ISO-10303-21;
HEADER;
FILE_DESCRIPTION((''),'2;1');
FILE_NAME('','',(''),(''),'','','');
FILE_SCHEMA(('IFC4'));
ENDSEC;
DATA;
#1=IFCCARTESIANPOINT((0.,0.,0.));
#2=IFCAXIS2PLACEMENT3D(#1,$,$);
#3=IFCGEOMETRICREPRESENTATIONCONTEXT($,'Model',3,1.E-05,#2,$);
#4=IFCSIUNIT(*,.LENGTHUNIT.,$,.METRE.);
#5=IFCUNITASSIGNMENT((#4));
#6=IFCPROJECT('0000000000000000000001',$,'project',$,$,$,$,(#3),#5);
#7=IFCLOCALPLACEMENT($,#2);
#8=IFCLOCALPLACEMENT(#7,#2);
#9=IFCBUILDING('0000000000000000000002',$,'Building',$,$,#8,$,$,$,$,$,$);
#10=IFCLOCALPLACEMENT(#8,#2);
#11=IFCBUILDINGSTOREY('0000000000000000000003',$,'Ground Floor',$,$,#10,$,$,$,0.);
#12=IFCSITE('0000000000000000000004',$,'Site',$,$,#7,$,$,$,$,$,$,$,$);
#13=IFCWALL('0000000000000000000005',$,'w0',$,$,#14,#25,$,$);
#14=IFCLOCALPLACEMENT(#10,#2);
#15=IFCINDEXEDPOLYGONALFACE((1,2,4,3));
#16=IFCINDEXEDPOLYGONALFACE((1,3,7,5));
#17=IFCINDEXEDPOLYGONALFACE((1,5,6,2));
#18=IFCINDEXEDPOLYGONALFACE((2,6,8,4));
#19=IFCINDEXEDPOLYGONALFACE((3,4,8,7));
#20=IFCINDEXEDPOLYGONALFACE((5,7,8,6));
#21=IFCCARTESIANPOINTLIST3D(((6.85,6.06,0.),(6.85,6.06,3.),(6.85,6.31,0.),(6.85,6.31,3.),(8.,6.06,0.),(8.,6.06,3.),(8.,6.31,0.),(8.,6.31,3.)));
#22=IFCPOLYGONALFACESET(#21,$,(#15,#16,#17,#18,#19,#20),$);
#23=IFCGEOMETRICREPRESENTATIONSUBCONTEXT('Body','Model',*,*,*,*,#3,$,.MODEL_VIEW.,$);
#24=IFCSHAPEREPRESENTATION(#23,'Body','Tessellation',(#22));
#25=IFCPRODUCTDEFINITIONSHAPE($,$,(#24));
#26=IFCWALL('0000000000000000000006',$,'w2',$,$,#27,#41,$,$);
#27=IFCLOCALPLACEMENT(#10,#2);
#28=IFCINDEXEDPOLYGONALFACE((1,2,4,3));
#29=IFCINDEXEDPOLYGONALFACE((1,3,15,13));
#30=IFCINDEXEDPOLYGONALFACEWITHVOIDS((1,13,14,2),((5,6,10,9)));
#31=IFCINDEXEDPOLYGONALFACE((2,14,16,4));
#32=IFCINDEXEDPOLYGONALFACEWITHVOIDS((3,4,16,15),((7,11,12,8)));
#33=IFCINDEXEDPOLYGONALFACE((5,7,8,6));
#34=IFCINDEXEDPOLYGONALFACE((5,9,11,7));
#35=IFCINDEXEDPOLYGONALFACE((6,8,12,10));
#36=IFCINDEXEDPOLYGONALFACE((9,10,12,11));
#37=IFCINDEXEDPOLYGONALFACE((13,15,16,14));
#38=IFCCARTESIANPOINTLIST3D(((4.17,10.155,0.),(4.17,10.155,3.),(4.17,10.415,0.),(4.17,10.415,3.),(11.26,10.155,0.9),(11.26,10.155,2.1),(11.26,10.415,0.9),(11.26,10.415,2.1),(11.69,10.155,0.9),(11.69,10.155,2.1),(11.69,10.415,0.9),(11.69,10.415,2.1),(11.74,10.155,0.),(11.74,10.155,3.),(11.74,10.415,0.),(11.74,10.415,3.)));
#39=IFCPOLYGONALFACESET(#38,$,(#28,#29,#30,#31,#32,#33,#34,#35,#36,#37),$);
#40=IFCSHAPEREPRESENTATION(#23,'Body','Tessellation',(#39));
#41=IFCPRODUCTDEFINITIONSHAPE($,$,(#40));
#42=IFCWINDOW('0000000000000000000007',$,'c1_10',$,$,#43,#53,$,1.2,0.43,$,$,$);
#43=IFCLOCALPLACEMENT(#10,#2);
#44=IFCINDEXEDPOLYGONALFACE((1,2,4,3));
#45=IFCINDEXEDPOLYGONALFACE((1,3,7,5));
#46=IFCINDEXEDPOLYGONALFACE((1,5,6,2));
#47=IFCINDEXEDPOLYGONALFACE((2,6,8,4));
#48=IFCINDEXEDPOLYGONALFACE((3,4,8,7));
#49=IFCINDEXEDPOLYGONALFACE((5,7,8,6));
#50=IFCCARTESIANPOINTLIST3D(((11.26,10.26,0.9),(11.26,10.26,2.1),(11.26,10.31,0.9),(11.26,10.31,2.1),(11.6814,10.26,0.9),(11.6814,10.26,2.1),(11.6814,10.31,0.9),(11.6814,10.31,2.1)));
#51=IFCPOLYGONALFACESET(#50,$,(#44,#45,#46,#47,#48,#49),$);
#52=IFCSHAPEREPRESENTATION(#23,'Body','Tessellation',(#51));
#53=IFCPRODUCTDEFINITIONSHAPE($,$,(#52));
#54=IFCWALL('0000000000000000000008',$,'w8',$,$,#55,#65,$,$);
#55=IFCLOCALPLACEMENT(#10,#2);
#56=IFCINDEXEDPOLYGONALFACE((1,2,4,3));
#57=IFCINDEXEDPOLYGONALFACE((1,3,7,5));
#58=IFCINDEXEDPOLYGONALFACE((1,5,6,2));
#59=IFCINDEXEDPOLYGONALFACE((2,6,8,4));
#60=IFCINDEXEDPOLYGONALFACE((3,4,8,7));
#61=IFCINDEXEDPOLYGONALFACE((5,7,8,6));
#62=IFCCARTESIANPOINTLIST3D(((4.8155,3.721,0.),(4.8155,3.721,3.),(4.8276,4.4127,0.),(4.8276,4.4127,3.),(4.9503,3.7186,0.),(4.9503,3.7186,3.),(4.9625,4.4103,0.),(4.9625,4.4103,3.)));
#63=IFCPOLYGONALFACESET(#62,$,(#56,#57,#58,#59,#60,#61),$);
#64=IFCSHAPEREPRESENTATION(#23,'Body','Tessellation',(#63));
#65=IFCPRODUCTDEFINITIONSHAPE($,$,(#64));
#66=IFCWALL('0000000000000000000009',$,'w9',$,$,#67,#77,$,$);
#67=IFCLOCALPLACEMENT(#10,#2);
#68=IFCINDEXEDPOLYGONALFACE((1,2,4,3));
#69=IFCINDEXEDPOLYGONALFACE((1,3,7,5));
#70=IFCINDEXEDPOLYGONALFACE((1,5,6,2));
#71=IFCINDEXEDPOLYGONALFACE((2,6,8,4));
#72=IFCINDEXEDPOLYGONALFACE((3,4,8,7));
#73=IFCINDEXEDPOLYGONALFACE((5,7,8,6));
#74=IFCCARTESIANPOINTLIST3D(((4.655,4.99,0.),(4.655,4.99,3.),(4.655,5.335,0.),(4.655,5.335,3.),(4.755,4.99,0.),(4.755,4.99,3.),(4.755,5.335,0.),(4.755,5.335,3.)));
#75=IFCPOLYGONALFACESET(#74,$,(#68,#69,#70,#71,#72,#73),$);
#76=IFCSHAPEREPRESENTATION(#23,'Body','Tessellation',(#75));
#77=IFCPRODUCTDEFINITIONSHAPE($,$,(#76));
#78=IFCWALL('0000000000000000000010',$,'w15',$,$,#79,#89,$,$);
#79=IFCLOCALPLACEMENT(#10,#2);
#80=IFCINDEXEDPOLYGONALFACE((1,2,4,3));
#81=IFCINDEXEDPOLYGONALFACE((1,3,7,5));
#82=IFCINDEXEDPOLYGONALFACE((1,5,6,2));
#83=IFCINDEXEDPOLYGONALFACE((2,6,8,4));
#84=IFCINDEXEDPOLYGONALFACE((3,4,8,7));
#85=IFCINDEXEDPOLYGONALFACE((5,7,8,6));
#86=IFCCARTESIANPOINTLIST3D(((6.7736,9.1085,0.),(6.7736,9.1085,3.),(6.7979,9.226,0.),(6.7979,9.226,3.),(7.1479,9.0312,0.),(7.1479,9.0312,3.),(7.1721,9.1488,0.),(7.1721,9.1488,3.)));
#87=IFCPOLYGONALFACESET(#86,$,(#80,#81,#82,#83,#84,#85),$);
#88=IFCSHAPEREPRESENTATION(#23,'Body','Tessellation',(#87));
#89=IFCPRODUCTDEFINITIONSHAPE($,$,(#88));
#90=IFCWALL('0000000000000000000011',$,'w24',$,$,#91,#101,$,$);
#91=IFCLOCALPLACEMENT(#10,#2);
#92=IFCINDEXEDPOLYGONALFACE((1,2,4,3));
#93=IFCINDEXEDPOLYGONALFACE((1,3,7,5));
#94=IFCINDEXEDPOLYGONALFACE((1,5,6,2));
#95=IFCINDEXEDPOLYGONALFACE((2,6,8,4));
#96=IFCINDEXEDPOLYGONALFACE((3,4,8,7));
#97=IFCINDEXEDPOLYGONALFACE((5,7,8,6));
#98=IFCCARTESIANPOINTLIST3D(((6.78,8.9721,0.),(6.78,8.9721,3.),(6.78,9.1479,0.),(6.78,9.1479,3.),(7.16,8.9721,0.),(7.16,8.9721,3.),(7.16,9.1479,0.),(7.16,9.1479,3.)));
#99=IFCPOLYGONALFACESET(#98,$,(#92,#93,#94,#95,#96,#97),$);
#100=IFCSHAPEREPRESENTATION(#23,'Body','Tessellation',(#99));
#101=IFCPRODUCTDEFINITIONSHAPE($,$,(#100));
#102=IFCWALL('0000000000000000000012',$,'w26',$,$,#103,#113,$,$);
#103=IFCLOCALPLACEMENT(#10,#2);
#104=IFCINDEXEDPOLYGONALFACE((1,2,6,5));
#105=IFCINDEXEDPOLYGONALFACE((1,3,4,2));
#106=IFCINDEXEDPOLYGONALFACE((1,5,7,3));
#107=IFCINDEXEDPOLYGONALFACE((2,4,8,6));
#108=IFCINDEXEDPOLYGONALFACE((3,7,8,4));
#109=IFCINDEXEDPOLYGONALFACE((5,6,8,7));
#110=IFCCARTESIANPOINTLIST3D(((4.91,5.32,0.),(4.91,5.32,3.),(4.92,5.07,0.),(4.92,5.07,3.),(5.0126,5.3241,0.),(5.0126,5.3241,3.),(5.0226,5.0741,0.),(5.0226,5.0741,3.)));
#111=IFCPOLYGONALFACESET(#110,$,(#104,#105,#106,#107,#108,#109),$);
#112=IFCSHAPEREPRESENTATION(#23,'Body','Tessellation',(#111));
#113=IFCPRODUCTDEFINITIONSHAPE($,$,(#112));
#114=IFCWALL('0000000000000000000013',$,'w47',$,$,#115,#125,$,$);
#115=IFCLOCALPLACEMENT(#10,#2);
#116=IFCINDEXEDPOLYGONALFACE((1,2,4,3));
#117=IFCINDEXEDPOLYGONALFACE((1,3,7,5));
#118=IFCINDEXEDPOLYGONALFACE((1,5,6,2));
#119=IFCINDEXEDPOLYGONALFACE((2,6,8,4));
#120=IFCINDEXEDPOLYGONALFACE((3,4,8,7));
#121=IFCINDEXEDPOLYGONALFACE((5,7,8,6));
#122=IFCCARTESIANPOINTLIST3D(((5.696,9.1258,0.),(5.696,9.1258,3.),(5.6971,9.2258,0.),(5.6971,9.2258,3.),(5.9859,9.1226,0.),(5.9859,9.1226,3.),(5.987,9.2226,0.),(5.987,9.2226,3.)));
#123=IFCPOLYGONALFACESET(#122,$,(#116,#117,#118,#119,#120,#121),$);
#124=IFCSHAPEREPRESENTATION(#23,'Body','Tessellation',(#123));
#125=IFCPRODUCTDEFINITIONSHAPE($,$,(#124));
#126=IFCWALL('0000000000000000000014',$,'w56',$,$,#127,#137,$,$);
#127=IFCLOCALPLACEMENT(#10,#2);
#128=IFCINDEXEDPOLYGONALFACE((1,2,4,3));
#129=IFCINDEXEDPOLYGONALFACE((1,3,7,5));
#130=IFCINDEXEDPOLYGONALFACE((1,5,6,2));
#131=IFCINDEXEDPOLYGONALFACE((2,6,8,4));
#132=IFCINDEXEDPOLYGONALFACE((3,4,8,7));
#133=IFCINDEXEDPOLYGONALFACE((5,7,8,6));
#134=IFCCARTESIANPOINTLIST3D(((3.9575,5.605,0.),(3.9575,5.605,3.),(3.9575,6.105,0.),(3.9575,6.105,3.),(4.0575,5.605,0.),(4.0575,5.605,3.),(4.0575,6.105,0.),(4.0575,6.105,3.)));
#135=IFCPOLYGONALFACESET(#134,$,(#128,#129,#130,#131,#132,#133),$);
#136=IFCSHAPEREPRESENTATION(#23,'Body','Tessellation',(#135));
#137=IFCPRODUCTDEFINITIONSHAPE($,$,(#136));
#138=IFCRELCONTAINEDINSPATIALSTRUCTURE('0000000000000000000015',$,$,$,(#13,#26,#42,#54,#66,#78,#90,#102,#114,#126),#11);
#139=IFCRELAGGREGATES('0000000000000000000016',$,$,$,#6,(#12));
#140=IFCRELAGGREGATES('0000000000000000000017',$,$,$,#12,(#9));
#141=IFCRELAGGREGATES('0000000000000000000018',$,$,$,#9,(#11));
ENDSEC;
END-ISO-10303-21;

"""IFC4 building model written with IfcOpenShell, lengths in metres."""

from ifc_helpers import new_model, si_unit, frame, origin, place, context, subcontext, project, spatial, polyline, outline, extrude, element, fill, save


model = new_model("IFC4")

# Units and contexts
model_context = context("Model", 3, precision=1e-05, world=origin())
body_context = subcontext(model_context, "Body", "Model", "MODEL_VIEW")
ifc_project = project(units=[si_unit("LENGTHUNIT", "METRE")], contexts=[model_context])

# Site, building, storey
site_placement = place(None, origin())
site = spatial("IfcSite", under=ifc_project, at=site_placement, Name="Site")
building_placement = place(site_placement, origin())
building = spatial("IfcBuilding", under=site, at=building_placement, Name="Building")
storey_placement = place(building_placement, origin())
storey = spatial("IfcBuildingStorey", under=building, at=storey_placement, Name="Ground Floor", Elevation=0.0)

# Wall
wall_1_placement = place(storey_placement, frame((6.85, 6.185, 0.0), x_axis=(1.0, 0.0, 0.0)))
element("IfcWall", 1, at=wall_1_placement, inside=storey, Name="w0", context=body_context, shape_type="SweptSolid", body=[
    extrude(outline(polyline([(0.0, -0.125), (1.15, -0.125), (1.15, 0.125), (0.0, 0.125), (0.0, -0.125)])), origin(), (0.0, 0.0, 1.0), 3.0),
])

# Wall, opening, window
wall_2_placement = place(storey_placement, frame((4.17, 10.285, 0.0), x_axis=(1.0, 0.0, 0.0)))
wall_2 = element("IfcWall", 2, at=wall_2_placement, inside=storey, Name="w2", context=body_context, shape_type="SweptSolid", body=[
    extrude(outline(polyline([(0.0, -0.13), (7.57, -0.13), (7.57, 0.13), (0.0, 0.13), (0.0, -0.13)])), origin(), (0.0, 0.0, 1.0), 3.0),
])
opening_placement = place(wall_2_placement, frame((7.09, 0.0, 0.0)))
opening = element("IfcOpeningElement", 3, at=opening_placement, cuts=wall_2, context=body_context, shape_type="SweptSolid", body=[
    extrude(outline(polyline([(0.0, -0.1365), (0.43, -0.1365), (0.43, 0.1365), (0.0, 0.1365), (0.0, -0.1365)])), frame((0.0, 0.0, 0.9)), (0.0, 0.0, 1.0), 1.2),
])
window_placement = place(wall_2_placement, frame((7.09, 0.0, 0.0)))
window = element("IfcWindow", 4, at=window_placement, inside=storey, Name="c1_10", OverallHeight=1.2, OverallWidth=0.43, context=body_context, shape_type="SweptSolid", body=[
    extrude(outline(polyline([(0.0, -0.025), (0.4214, -0.025), (0.4214, 0.025), (0.0, 0.025), (0.0, -0.025)])), frame((0.0, 0.0, 0.9)), (0.0, 0.0, 1.0), 1.2),
])
fill(opening, window)

# Walls
wall_3_placement = place(storey_placement, frame((4.8829, 3.7198, 0.0), x_axis=(0.017538, 0.999846, 0.0)))
element("IfcWall", 5, at=wall_3_placement, inside=storey, Name="w8", context=body_context, shape_type="SweptSolid", body=[
    extrude(outline(polyline([(0.0, -0.0674), (0.6918, -0.0674), (0.6918, 0.0674), (0.0, 0.0674), (0.0, -0.0674)])), origin(), (0.0, 0.0, 1.0), 3.0),
])
wall_4_placement = place(storey_placement, frame((4.705, 4.99, 0.0), x_axis=(0.0, 1.0, 0.0)))
element("IfcWall", 6, at=wall_4_placement, inside=storey, Name="w9", context=body_context, shape_type="SweptSolid", body=[
    extrude(outline(polyline([(0.0, -0.05), (0.345, -0.05), (0.345, 0.05), (0.0, 0.05), (0.0, -0.05)])), origin(), (0.0, 0.0, 1.0), 3.0),
])
wall_5_placement = place(storey_placement, frame((6.7857, 9.1672, 0.0), x_axis=(0.979367, -0.202091, 0.0)))
element("IfcWall", 7, at=wall_5_placement, inside=storey, Name="w15", context=body_context, shape_type="SweptSolid", body=[
    extrude(outline(polyline([(0.0, -0.06), (0.3822, -0.06), (0.3822, 0.06), (0.0, 0.06), (0.0, -0.06)])), origin(), (0.0, 0.0, 1.0), 3.0),
])
wall_6_placement = place(storey_placement, frame((6.78, 9.06, 0.0), x_axis=(1.0, 0.0, 0.0)))
element("IfcWall", 8, at=wall_6_placement, inside=storey, Name="w24", context=body_context, shape_type="SweptSolid", body=[
    extrude(outline(polyline([(0.0, -0.0879), (0.38, -0.0879), (0.38, 0.0879), (0.0, 0.0879), (0.0, -0.0879)])), origin(), (0.0, 0.0, 1.0), 3.0),
])
wall_7_placement = place(storey_placement, frame((4.9613, 5.3221, 0.0), x_axis=(0.03996, -0.999201, 0.0)))
element("IfcWall", 9, at=wall_7_placement, inside=storey, Name="w26", context=body_context, shape_type="SweptSolid", body=[
    extrude(outline(polyline([(0.0, -0.0514), (0.2502, -0.0514), (0.2502, 0.0514), (0.0, 0.0514), (0.0, -0.0514)])), origin(), (0.0, 0.0, 1.0), 3.0),
])
wall_8_placement = place(storey_placement, frame((5.6965, 9.1758, 0.0), x_axis=(0.999939, -0.011026, 0.0)))
element("IfcWall", 10, at=wall_8_placement, inside=storey, Name="w47", context=body_context, shape_type="SweptSolid", body=[
    extrude(outline(polyline([(0.0, -0.05), (0.2899, -0.05), (0.2899, 0.05), (0.0, 0.05), (0.0, -0.05)])), origin(), (0.0, 0.0, 1.0), 3.0),
])
wall_9_placement = place(storey_placement, frame((4.0075, 5.605, 0.0), x_axis=(0.0, 1.0, 0.0)))
element("IfcWall", 11, at=wall_9_placement, inside=storey, Name="w56", context=body_context, shape_type="SweptSolid", body=[
    extrude(outline(polyline([(0.0, -0.05), (0.5, -0.05), (0.5, 0.05), (0.0, 0.05), (0.0, -0.05)])), origin(), (0.0, 0.0, 1.0), 3.0),
])

save(model, "model.ifc")
